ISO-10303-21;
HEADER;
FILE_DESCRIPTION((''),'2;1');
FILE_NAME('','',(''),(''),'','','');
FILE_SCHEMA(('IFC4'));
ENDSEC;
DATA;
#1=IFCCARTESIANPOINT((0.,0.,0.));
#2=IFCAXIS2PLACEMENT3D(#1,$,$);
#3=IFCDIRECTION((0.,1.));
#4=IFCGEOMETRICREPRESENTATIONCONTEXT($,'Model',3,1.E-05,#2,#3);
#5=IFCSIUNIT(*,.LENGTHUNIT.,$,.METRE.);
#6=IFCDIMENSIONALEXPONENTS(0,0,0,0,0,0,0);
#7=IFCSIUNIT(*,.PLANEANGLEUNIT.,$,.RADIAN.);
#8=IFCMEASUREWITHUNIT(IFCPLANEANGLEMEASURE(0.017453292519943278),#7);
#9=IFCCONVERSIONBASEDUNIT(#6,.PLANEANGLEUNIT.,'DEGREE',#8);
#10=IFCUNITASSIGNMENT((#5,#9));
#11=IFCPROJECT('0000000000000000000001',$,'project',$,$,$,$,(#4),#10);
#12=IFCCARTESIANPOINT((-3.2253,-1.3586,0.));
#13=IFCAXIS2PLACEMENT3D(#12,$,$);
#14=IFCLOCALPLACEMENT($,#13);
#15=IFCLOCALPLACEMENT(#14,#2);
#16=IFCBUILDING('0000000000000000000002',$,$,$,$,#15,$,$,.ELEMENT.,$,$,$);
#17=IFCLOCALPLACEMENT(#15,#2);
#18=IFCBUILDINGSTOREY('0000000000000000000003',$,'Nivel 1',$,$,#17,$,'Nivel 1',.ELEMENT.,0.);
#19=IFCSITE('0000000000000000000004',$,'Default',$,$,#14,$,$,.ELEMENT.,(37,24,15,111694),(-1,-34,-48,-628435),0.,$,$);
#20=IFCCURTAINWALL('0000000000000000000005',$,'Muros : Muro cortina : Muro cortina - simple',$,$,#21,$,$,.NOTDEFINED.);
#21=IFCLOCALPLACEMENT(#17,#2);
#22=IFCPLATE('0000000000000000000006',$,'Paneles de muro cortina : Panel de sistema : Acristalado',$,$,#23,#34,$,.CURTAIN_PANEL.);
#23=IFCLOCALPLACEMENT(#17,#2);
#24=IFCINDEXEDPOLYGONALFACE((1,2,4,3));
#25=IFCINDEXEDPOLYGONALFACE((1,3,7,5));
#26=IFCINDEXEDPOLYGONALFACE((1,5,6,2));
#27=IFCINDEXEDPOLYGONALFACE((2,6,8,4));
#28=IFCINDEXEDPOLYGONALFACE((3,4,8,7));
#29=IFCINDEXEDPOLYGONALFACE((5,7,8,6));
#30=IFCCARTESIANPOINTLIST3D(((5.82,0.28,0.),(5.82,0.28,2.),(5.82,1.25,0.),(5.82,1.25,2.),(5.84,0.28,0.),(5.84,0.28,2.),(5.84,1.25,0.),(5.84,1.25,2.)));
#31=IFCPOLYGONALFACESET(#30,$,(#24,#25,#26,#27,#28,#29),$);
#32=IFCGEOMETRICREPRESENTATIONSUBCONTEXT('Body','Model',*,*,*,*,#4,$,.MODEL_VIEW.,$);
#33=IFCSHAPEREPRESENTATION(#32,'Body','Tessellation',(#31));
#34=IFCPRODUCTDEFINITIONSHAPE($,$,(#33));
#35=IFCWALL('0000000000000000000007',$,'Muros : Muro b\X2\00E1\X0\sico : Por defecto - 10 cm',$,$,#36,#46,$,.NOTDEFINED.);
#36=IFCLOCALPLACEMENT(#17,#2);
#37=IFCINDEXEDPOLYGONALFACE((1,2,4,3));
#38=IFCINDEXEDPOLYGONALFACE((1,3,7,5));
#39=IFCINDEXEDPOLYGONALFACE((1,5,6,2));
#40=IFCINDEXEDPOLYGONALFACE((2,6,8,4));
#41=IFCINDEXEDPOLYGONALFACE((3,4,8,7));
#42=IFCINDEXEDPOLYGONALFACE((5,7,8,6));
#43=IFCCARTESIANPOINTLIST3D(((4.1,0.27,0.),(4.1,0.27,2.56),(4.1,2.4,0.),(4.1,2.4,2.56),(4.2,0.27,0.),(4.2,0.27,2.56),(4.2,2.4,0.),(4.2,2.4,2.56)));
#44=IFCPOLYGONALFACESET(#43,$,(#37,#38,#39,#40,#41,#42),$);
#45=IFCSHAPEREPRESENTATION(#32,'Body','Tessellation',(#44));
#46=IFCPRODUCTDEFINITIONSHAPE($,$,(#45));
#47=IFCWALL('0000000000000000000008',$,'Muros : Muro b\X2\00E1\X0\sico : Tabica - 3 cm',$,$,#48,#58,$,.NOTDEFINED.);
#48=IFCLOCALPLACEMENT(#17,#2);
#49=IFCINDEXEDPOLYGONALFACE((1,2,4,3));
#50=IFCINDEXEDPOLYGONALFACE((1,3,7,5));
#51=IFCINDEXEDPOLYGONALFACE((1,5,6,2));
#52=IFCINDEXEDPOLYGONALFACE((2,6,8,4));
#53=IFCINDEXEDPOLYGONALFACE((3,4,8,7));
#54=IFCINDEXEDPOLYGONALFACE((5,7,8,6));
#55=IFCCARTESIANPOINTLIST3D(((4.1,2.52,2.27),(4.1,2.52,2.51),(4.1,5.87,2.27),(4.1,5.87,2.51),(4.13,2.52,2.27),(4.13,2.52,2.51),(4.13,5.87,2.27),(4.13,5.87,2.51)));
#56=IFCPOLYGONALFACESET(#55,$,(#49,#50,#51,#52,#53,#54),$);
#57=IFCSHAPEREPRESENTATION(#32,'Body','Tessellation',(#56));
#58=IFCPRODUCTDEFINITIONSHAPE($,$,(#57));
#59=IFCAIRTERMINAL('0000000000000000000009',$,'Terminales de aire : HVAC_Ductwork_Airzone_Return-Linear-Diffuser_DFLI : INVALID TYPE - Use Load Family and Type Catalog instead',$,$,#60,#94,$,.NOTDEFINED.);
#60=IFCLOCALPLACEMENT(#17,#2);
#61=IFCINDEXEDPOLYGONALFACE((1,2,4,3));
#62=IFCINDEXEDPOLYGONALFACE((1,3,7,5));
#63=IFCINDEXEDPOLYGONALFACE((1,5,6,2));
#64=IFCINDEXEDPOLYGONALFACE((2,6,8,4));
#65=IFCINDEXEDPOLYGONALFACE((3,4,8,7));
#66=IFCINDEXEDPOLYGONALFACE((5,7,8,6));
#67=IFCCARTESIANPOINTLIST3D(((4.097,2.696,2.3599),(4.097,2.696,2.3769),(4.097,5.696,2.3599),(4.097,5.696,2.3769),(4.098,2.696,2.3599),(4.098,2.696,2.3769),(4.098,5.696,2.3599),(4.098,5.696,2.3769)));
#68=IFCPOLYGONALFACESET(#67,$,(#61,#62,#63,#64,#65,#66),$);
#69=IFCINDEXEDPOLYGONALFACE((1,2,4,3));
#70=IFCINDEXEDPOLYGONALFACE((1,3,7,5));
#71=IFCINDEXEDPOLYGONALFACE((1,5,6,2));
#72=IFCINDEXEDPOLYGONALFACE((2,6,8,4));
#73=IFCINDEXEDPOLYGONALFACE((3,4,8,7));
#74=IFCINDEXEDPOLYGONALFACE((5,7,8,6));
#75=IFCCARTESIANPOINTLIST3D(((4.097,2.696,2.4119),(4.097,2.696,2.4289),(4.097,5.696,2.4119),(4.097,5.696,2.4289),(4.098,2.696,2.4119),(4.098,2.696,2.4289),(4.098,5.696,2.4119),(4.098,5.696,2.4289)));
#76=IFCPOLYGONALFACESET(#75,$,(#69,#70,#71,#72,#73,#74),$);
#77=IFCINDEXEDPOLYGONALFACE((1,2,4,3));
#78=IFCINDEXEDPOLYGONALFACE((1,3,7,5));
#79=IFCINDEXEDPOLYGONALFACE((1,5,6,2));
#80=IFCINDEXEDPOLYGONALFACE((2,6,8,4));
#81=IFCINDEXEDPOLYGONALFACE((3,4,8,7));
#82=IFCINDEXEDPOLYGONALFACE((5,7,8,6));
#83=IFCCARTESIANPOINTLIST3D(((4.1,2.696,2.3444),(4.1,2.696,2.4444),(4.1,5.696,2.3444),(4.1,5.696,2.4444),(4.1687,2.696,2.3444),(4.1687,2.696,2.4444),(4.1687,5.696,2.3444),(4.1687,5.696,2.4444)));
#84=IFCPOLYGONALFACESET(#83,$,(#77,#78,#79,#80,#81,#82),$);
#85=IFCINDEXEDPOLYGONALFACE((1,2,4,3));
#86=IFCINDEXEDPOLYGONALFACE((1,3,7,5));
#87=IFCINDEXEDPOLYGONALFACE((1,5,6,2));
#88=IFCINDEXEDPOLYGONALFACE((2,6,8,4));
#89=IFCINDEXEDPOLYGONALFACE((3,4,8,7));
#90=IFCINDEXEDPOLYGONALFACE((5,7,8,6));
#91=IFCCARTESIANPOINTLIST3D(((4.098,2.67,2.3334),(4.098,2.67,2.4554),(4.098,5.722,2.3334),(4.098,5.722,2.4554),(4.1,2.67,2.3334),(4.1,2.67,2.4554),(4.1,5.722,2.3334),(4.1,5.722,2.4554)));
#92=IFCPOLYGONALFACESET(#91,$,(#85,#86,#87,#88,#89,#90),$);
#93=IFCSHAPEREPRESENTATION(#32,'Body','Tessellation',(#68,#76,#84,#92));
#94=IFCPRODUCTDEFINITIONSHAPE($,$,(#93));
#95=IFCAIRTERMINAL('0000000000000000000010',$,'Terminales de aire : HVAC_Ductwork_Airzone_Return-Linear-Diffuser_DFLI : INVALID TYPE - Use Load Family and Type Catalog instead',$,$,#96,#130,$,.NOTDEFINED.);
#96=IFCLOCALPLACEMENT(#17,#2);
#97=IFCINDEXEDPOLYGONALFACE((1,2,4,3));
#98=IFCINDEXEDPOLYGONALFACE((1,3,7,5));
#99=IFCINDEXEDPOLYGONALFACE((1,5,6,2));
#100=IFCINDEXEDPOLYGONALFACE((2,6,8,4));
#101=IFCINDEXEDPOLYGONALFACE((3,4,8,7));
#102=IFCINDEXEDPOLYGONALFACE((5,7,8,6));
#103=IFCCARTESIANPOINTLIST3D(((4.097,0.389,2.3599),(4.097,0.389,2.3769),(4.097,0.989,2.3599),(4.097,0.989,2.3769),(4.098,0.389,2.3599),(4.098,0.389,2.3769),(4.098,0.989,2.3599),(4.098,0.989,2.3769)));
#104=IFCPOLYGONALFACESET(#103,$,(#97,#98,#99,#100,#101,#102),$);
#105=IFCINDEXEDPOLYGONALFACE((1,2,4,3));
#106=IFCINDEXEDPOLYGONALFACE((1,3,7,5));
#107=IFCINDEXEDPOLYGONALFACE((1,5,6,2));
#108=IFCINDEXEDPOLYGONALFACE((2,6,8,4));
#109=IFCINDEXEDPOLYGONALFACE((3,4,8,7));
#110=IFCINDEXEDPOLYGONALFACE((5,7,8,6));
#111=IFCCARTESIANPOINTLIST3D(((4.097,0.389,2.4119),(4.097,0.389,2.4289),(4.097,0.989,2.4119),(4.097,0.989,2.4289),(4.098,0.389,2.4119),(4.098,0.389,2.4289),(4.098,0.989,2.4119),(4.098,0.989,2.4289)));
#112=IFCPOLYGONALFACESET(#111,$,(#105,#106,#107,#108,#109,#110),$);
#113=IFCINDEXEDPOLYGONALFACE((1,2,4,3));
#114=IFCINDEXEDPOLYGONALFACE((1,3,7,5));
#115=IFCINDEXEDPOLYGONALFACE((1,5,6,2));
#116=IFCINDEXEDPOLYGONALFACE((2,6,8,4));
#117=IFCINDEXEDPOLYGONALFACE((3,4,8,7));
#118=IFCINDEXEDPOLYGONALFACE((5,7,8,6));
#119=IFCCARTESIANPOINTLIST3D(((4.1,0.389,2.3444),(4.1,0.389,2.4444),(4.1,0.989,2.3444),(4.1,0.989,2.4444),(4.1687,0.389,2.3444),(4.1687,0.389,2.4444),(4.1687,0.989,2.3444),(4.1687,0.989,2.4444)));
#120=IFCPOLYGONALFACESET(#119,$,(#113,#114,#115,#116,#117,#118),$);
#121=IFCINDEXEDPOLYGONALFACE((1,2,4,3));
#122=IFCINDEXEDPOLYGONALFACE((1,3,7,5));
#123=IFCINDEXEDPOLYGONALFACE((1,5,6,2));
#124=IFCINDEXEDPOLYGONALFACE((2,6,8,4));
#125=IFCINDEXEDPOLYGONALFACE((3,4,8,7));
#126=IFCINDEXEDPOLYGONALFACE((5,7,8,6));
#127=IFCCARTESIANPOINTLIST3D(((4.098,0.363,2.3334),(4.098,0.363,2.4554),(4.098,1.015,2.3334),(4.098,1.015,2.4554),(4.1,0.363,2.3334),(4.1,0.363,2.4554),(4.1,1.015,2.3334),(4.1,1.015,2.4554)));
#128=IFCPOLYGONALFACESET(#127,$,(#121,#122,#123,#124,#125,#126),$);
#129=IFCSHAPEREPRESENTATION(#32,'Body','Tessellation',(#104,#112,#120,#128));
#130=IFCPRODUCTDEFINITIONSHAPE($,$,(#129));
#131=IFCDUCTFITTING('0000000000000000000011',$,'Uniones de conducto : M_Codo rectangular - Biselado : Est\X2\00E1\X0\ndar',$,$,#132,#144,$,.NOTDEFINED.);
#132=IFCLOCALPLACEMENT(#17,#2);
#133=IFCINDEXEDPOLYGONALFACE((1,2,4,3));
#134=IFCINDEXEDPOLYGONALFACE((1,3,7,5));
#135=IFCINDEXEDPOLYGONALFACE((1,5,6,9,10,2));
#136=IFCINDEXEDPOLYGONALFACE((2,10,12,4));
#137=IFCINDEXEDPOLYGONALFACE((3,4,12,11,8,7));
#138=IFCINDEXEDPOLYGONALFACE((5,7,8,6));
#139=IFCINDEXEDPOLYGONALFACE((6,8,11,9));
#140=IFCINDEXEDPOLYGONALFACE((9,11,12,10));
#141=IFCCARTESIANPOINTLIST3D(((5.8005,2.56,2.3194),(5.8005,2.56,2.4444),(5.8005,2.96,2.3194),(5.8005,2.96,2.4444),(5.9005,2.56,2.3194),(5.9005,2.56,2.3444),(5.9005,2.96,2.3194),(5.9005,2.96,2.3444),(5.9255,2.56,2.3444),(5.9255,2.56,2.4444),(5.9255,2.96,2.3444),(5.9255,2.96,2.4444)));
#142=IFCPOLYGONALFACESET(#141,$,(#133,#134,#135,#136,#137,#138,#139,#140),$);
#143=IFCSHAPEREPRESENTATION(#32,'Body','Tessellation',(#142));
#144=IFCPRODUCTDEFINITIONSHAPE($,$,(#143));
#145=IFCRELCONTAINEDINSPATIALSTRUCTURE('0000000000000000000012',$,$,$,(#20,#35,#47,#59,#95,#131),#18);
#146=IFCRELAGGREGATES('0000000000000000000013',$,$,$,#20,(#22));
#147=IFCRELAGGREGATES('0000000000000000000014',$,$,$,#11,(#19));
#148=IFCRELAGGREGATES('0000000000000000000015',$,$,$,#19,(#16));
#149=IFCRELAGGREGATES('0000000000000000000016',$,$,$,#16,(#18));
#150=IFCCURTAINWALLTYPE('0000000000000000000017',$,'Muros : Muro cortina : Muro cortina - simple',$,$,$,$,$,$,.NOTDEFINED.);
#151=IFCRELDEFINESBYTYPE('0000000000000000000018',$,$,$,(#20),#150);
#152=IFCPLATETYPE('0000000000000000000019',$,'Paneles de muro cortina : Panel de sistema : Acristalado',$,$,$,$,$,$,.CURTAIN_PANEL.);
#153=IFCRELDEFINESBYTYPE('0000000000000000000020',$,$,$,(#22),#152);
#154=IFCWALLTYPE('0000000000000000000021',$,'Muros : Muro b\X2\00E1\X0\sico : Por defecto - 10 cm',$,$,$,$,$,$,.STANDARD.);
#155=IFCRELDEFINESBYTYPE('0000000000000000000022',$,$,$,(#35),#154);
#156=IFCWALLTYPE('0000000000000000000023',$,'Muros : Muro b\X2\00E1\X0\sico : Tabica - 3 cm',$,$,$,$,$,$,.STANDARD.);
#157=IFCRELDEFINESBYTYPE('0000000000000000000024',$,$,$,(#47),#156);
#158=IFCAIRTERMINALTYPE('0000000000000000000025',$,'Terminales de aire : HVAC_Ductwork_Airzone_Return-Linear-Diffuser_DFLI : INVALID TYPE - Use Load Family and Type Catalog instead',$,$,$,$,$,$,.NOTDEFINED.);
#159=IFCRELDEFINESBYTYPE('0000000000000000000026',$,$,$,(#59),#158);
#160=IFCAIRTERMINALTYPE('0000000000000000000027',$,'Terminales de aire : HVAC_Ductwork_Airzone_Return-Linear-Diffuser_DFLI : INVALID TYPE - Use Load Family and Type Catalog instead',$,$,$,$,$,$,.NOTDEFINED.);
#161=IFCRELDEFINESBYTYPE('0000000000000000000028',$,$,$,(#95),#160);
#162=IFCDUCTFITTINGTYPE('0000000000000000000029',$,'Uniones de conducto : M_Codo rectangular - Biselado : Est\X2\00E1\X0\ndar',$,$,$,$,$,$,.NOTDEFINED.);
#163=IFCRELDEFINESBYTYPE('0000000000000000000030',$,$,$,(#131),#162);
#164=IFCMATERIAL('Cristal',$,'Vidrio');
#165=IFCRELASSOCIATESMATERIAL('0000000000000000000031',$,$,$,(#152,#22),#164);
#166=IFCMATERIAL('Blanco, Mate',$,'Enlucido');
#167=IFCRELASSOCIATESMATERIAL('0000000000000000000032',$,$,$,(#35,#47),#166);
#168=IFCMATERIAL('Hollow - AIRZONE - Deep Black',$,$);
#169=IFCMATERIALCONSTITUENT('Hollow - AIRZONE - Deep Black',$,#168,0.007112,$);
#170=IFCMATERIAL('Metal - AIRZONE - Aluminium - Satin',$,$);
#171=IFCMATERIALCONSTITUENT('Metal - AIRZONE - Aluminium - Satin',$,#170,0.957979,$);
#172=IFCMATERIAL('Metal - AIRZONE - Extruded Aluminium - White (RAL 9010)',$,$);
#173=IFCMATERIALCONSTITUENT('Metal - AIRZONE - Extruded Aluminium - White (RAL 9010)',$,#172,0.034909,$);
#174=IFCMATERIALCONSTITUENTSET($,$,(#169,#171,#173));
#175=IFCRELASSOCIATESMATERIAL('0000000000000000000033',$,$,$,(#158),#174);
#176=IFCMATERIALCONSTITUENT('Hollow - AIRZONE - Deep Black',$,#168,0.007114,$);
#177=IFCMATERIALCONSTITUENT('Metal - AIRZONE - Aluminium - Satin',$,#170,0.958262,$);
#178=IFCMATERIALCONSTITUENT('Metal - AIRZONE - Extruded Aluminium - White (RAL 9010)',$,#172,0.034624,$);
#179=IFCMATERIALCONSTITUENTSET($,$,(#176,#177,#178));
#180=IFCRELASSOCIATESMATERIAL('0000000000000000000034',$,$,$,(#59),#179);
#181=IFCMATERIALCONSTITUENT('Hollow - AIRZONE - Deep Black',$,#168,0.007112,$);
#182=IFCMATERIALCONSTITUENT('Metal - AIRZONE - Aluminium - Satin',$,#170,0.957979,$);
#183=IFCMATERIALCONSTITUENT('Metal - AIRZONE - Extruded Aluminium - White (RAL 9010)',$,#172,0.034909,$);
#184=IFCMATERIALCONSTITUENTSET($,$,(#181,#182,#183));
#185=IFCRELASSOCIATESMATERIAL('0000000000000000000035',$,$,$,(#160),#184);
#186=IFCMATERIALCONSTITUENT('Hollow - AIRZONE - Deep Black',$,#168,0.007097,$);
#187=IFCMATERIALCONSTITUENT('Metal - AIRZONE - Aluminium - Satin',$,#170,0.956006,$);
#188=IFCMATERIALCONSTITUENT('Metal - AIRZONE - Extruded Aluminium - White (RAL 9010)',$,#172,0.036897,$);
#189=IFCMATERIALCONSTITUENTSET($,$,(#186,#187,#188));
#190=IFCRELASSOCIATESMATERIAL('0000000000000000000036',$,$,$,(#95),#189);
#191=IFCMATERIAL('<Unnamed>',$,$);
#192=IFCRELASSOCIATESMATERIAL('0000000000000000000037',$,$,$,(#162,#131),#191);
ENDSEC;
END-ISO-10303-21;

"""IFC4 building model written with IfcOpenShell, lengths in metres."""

from ifc_helpers import new_model, entity, si_unit, converted_unit, direction, frame, origin, place, context, subcontext, project, spatial, indexed_curve, outline, extrude, source, transform, mapped, material, constituent, constituent_set, type_object, type_shapes, element, aggregate, save


model = new_model("IFC4")

# Units and contexts
model_context = context("Model", 3, precision=1e-05, world=origin(), true_north=direction((0.0, 1.0)))
body_context = subcontext(model_context, "Body", "Model", "MODEL_VIEW")
ifc_project = project(units=[si_unit("LENGTHUNIT", "METRE"), converted_unit("PLANEANGLEUNIT", "DEGREE", entity("IfcPlaneAngleMeasure", 0.017453292519943278), si_unit("PLANEANGLEUNIT", "RADIAN"), dimensions=[0, 0, 0, 0, 0, 0, 0])], contexts=[model_context])

# Site, building, storey
site_placement = place(None, frame((-3.2253, -1.3586, 0.0)))
site = spatial("IfcSite", under=ifc_project, at=site_placement, Name="Default", CompositionType="ELEMENT", RefLatitude=(37, 24, 15, 111694), RefLongitude=(-1, -34, -48, -628435), RefElevation=0.0)
building_placement = place(site_placement, origin())
building = spatial("IfcBuilding", under=site, at=building_placement, CompositionType="ELEMENT")
storey_placement = place(building_placement, origin())
storey = spatial("IfcBuildingStorey", under=building, at=storey_placement, Name="Nivel 1", LongName="Nivel 1", CompositionType="ELEMENT", Elevation=0.0)

# Curtain wall, plate
curtain_wall_type = type_object("IfcCurtainWallType", Name="Muros : Muro cortina : Muro cortina - simple", PredefinedType="NOTDEFINED")
curtain_wall_placement = place(storey_placement, origin())
curtain_wall = element("IfcCurtainWall", 1, at=curtain_wall_placement, inside=storey, type_object=curtain_wall_type, Name="Muros : Muro cortina : Muro cortina - simple", PredefinedType="NOTDEFINED")
ifc_material_1 = material(Name="Cristal", Category="Vidrio")
plate_type = type_object("IfcPlateType", Name="Paneles de muro cortina : Panel de sistema : Acristalado", PredefinedType="CURTAIN_PANEL", material=ifc_material_1)
shared_shape_1 = source(origin(), body_context, "Body", "SweptSolid", [
    extrude(outline(indexed_curve([(-0.01, -0.485), (0.01, -0.485), (0.01, 0.485), (-0.01, 0.485), (-0.01, -0.485)], self_intersect=False)), frame((0.0, 0.0, 0.0), z_axis=(0.0, 0.0, 1.0), x_axis=(0.0, 1.0, 0.0)), (0.0, 0.0, 1.0), 2.0),
])
type_shapes(plate_type, [shared_shape_1])
plate_placement = place(curtain_wall_placement, frame((5.83, 0.765, 0.0), z_axis=(0.0, 0.0, 1.0), x_axis=(0.0, -1.0, 0.0)))
plate = element("IfcPlate", 2, at=plate_placement, type_object=plate_type, material=ifc_material_1, Name="Paneles de muro cortina : Panel de sistema : Acristalado", PredefinedType="CURTAIN_PANEL", context=body_context, shape_type="MappedRepresentation", body=[
    mapped(shared_shape_1, transform((0.0, 0.0, 0.0), scale=1.0)),
])
aggregate(curtain_wall, [plate])

# Walls
ifc_material_2 = material(Name="Blanco, Mate", Category="Enlucido")
wall_type_1 = type_object("IfcWallType", Name="Muros : Muro básico : Por defecto - 10 cm", PredefinedType="STANDARD")
wall_1_placement = place(storey_placement, frame((4.15, 2.4, 0.0), z_axis=(0.0, 0.0, 1.0), x_axis=(0.0, -1.0, 0.0)))
element("IfcWall", 3, at=wall_1_placement, inside=storey, type_object=wall_type_1, material=ifc_material_2, Name="Muros : Muro básico : Por defecto - 10 cm", PredefinedType="NOTDEFINED", context=body_context, shape_type="SweptSolid", body=[
    extrude(outline(indexed_curve([(2.13, 0.05), (0.0, 0.05), (0.0, -0.05), (2.13, -0.05), (2.13, 0.05)], self_intersect=False)), origin(), (0.0, 0.0, 1.0), 2.56),
])
wall_type_2 = type_object("IfcWallType", Name="Muros : Muro básico : Tabica - 3 cm", PredefinedType="STANDARD")
wall_2_placement = place(storey_placement, frame((4.115, 2.52, 2.27), z_axis=(0.0, 0.0, 1.0), x_axis=(0.0, 1.0, 0.0)))
element("IfcWall", 4, at=wall_2_placement, inside=storey, type_object=wall_type_2, material=ifc_material_2, Name="Muros : Muro básico : Tabica - 3 cm", PredefinedType="NOTDEFINED", context=body_context, shape_type="SweptSolid", body=[
    extrude(outline(indexed_curve([(3.35, 0.015), (0.0, 0.015), (0.0, -0.015), (3.35, -0.015), (3.35, 0.015)], self_intersect=False)), origin(), (0.0, 0.0, 1.0), 0.24),
])

# Shared definitions
ifc_material_3 = material(Name="<Unnamed>")

# Air terminals
ifc_material_4 = material(Name="Hollow - AIRZONE - Deep Black")
ifc_constituent_1 = constituent(ifc_material_4, Name="Hollow - AIRZONE - Deep Black", fraction=0.007114)
ifc_material_5 = material(Name="Metal - AIRZONE - Aluminium - Satin")
ifc_constituent_2 = constituent(ifc_material_5, Name="Metal - AIRZONE - Aluminium - Satin", fraction=0.958262)
ifc_material_6 = material(Name="Metal - AIRZONE - Extruded Aluminium - White (RAL 9010)")
ifc_constituent_3 = constituent(ifc_material_6, Name="Metal - AIRZONE - Extruded Aluminium - White (RAL 9010)", fraction=0.034624)
ifc_constituent_set_1 = constituent_set(constituents=[ifc_constituent_1, ifc_constituent_2, ifc_constituent_3])
ifc_constituent_4 = constituent(ifc_material_4, Name="Hollow - AIRZONE - Deep Black", fraction=0.007112)
ifc_constituent_5 = constituent(ifc_material_5, Name="Metal - AIRZONE - Aluminium - Satin", fraction=0.957979)
ifc_constituent_6 = constituent(ifc_material_6, Name="Metal - AIRZONE - Extruded Aluminium - White (RAL 9010)", fraction=0.034909)
ifc_constituent_set_2 = constituent_set(constituents=[ifc_constituent_4, ifc_constituent_5, ifc_constituent_6])
air_terminal_type_1 = type_object("IfcAirTerminalType", Name="Terminales de aire : HVAC_Ductwork_Airzone_Return-Linear-Diffuser_DFLI : INVALID TYPE - Use Load Family and Type Catalog instead", PredefinedType="NOTDEFINED", material=ifc_constituent_set_2)
shared_shape_2 = source(origin(), body_context, "Body", "SweptSolid", [
    extrude(outline(indexed_curve([(-0.0085, -1.5), (0.0085, -1.5), (0.0085, 1.5), (-0.0085, 1.5), (-0.0085, -1.5)], self_intersect=False)), frame((0.0, 0.026, -0.003), z_axis=(0.0, 0.0, 1.0), x_axis=(0.0, 1.0, 0.0)), (0.0, 0.0, 1.0), 0.001),
    extrude(outline(indexed_curve([(-0.0085, -1.5), (0.0085, -1.5), (0.0085, 1.5), (-0.0085, 1.5), (-0.0085, -1.5)], self_intersect=False)), frame((0.0, -0.026, -0.003), z_axis=(0.0, 0.0, 1.0), x_axis=(0.0, 1.0, 0.0)), (0.0, 0.0, 1.0), 0.001),
    extrude(outline(indexed_curve([(-1.5, -0.05), (1.5, -0.05), (1.5, 0.05), (-1.5, 0.05), (-1.5, -0.05)], self_intersect=False)), frame((0.0, 0.0, 0.0), z_axis=(0.0, 0.0, 1.0), x_axis=(-1.0, 0.0, 0.0)), (0.0, 0.0, 1.0), 0.0687),
    extrude(outline(indexed_curve([(-1.526, -0.061), (1.526, -0.061), (1.526, 0.061), (-1.526, 0.061), (-1.526, -0.061)], self_intersect=False)), frame((0.0, 0.0, -0.002), z_axis=(0.0, 0.0, 1.0), x_axis=(-1.0, 0.0, 0.0)), (0.0, 0.0, 1.0), 0.002),
])
type_shapes(air_terminal_type_1, [shared_shape_2])
air_terminal_1_placement = place(storey_placement, frame((4.1, 4.196, 2.3944), z_axis=(1.0, 0.0, 0.0), x_axis=(0.0, -1.0, 0.0)))
element("IfcAirTerminal", 5, at=air_terminal_1_placement, inside=storey, type_object=air_terminal_type_1, material=ifc_constituent_set_1, Name="Terminales de aire : HVAC_Ductwork_Airzone_Return-Linear-Diffuser_DFLI : INVALID TYPE - Use Load Family and Type Catalog instead", PredefinedType="NOTDEFINED", context=body_context, shape_type="MappedRepresentation", body=[
    mapped(shared_shape_2, transform((0.0, 0.0, 0.0), scale=1.0)),
])
ifc_constituent_7 = constituent(ifc_material_4, Name="Hollow - AIRZONE - Deep Black", fraction=0.007097)
ifc_constituent_8 = constituent(ifc_material_5, Name="Metal - AIRZONE - Aluminium - Satin", fraction=0.956006)
ifc_constituent_9 = constituent(ifc_material_6, Name="Metal - AIRZONE - Extruded Aluminium - White (RAL 9010)", fraction=0.036897)
ifc_constituent_set_3 = constituent_set(constituents=[ifc_constituent_7, ifc_constituent_8, ifc_constituent_9])
ifc_constituent_10 = constituent(ifc_material_4, Name="Hollow - AIRZONE - Deep Black", fraction=0.007112)
ifc_constituent_11 = constituent(ifc_material_5, Name="Metal - AIRZONE - Aluminium - Satin", fraction=0.957979)
ifc_constituent_12 = constituent(ifc_material_6, Name="Metal - AIRZONE - Extruded Aluminium - White (RAL 9010)", fraction=0.034909)
ifc_constituent_set_4 = constituent_set(constituents=[ifc_constituent_10, ifc_constituent_11, ifc_constituent_12])
air_terminal_type_2 = type_object("IfcAirTerminalType", Name="Terminales de aire : HVAC_Ductwork_Airzone_Return-Linear-Diffuser_DFLI : INVALID TYPE - Use Load Family and Type Catalog instead", PredefinedType="NOTDEFINED", material=ifc_constituent_set_4)
shared_shape_3 = source(origin(), body_context, "Body", "SweptSolid", [
    extrude(outline(indexed_curve([(-0.0085, -0.3), (0.0085, -0.3), (0.0085, 0.3), (-0.0085, 0.3), (-0.0085, -0.3)], self_intersect=False)), frame((0.0, 0.026, -0.003), z_axis=(0.0, 0.0, 1.0), x_axis=(0.0, 1.0, 0.0)), (0.0, 0.0, 1.0), 0.001),
    extrude(outline(indexed_curve([(-0.0085, -0.3), (0.0085, -0.3), (0.0085, 0.3), (-0.0085, 0.3), (-0.0085, -0.3)], self_intersect=False)), frame((0.0, -0.026, -0.003), z_axis=(0.0, 0.0, 1.0), x_axis=(0.0, 1.0, 0.0)), (0.0, 0.0, 1.0), 0.001),
    extrude(outline(indexed_curve([(-0.3, -0.05), (0.3, -0.05), (0.3, 0.05), (-0.3, 0.05), (-0.3, -0.05)], self_intersect=False)), frame((0.0, 0.0, 0.0), z_axis=(0.0, 0.0, 1.0), x_axis=(-1.0, 0.0, 0.0)), (0.0, 0.0, 1.0), 0.0687),
    extrude(outline(indexed_curve([(-0.326, -0.061), (0.326, -0.061), (0.326, 0.061), (-0.326, 0.061), (-0.326, -0.061)], self_intersect=False)), frame((0.0, 0.0, -0.002), z_axis=(0.0, 0.0, 1.0), x_axis=(-1.0, 0.0, 0.0)), (0.0, 0.0, 1.0), 0.002),
])
type_shapes(air_terminal_type_2, [shared_shape_3])
air_terminal_2_placement = place(storey_placement, frame((4.1, 0.689, 2.3944), z_axis=(1.0, 0.0, 0.0), x_axis=(0.0, -1.0, 0.0)))
element("IfcAirTerminal", 6, at=air_terminal_2_placement, inside=storey, type_object=air_terminal_type_2, material=ifc_constituent_set_3, Name="Terminales de aire : HVAC_Ductwork_Airzone_Return-Linear-Diffuser_DFLI : INVALID TYPE - Use Load Family and Type Catalog instead", PredefinedType="NOTDEFINED", context=body_context, shape_type="MappedRepresentation", body=[
    mapped(shared_shape_3, transform((0.0, 0.0, 0.0), scale=1.0)),
])

# Duct fitting
duct_fitting_type_1 = type_object("IfcDuctFittingType", Name="Uniones de conducto : M_Codo rectangular - Biselado : Estándar", PredefinedType="NOTDEFINED", material=ifc_material_3)
shared_shape_4 = source(origin(), body_context, "Body", "SweptSolid", [
    extrude(outline(indexed_curve([(-0.05, -0.075), (0.075, -0.075), (0.075, 0.05), (-0.025, 0.05), (-0.025, 0.025), (-0.05, 0.025), (-0.05, -0.075)], self_intersect=False)), frame((-0.025, 0.025, -0.2)), (0.0, 0.0, 1.0), 0.4),
])
type_shapes(duct_fitting_type_1, [shared_shape_4])
duct_fitting_1_placement = place(storey_placement, frame((5.8505, 2.76, 2.3944), z_axis=(0.0, -1.0, 0.0), x_axis=(-1.0, 0.0, 0.0)))
element("IfcDuctFitting", 7, at=duct_fitting_1_placement, inside=storey, type_object=duct_fitting_type_1, material=ifc_material_3, Name="Uniones de conducto : M_Codo rectangular - Biselado : Estándar", PredefinedType="NOTDEFINED", context=body_context, shape_type="MappedRepresentation", body=[
    mapped(shared_shape_4, transform((0.0, 0.0, 0.0), scale=1.0)),
])

save(model, "model.ifc")
